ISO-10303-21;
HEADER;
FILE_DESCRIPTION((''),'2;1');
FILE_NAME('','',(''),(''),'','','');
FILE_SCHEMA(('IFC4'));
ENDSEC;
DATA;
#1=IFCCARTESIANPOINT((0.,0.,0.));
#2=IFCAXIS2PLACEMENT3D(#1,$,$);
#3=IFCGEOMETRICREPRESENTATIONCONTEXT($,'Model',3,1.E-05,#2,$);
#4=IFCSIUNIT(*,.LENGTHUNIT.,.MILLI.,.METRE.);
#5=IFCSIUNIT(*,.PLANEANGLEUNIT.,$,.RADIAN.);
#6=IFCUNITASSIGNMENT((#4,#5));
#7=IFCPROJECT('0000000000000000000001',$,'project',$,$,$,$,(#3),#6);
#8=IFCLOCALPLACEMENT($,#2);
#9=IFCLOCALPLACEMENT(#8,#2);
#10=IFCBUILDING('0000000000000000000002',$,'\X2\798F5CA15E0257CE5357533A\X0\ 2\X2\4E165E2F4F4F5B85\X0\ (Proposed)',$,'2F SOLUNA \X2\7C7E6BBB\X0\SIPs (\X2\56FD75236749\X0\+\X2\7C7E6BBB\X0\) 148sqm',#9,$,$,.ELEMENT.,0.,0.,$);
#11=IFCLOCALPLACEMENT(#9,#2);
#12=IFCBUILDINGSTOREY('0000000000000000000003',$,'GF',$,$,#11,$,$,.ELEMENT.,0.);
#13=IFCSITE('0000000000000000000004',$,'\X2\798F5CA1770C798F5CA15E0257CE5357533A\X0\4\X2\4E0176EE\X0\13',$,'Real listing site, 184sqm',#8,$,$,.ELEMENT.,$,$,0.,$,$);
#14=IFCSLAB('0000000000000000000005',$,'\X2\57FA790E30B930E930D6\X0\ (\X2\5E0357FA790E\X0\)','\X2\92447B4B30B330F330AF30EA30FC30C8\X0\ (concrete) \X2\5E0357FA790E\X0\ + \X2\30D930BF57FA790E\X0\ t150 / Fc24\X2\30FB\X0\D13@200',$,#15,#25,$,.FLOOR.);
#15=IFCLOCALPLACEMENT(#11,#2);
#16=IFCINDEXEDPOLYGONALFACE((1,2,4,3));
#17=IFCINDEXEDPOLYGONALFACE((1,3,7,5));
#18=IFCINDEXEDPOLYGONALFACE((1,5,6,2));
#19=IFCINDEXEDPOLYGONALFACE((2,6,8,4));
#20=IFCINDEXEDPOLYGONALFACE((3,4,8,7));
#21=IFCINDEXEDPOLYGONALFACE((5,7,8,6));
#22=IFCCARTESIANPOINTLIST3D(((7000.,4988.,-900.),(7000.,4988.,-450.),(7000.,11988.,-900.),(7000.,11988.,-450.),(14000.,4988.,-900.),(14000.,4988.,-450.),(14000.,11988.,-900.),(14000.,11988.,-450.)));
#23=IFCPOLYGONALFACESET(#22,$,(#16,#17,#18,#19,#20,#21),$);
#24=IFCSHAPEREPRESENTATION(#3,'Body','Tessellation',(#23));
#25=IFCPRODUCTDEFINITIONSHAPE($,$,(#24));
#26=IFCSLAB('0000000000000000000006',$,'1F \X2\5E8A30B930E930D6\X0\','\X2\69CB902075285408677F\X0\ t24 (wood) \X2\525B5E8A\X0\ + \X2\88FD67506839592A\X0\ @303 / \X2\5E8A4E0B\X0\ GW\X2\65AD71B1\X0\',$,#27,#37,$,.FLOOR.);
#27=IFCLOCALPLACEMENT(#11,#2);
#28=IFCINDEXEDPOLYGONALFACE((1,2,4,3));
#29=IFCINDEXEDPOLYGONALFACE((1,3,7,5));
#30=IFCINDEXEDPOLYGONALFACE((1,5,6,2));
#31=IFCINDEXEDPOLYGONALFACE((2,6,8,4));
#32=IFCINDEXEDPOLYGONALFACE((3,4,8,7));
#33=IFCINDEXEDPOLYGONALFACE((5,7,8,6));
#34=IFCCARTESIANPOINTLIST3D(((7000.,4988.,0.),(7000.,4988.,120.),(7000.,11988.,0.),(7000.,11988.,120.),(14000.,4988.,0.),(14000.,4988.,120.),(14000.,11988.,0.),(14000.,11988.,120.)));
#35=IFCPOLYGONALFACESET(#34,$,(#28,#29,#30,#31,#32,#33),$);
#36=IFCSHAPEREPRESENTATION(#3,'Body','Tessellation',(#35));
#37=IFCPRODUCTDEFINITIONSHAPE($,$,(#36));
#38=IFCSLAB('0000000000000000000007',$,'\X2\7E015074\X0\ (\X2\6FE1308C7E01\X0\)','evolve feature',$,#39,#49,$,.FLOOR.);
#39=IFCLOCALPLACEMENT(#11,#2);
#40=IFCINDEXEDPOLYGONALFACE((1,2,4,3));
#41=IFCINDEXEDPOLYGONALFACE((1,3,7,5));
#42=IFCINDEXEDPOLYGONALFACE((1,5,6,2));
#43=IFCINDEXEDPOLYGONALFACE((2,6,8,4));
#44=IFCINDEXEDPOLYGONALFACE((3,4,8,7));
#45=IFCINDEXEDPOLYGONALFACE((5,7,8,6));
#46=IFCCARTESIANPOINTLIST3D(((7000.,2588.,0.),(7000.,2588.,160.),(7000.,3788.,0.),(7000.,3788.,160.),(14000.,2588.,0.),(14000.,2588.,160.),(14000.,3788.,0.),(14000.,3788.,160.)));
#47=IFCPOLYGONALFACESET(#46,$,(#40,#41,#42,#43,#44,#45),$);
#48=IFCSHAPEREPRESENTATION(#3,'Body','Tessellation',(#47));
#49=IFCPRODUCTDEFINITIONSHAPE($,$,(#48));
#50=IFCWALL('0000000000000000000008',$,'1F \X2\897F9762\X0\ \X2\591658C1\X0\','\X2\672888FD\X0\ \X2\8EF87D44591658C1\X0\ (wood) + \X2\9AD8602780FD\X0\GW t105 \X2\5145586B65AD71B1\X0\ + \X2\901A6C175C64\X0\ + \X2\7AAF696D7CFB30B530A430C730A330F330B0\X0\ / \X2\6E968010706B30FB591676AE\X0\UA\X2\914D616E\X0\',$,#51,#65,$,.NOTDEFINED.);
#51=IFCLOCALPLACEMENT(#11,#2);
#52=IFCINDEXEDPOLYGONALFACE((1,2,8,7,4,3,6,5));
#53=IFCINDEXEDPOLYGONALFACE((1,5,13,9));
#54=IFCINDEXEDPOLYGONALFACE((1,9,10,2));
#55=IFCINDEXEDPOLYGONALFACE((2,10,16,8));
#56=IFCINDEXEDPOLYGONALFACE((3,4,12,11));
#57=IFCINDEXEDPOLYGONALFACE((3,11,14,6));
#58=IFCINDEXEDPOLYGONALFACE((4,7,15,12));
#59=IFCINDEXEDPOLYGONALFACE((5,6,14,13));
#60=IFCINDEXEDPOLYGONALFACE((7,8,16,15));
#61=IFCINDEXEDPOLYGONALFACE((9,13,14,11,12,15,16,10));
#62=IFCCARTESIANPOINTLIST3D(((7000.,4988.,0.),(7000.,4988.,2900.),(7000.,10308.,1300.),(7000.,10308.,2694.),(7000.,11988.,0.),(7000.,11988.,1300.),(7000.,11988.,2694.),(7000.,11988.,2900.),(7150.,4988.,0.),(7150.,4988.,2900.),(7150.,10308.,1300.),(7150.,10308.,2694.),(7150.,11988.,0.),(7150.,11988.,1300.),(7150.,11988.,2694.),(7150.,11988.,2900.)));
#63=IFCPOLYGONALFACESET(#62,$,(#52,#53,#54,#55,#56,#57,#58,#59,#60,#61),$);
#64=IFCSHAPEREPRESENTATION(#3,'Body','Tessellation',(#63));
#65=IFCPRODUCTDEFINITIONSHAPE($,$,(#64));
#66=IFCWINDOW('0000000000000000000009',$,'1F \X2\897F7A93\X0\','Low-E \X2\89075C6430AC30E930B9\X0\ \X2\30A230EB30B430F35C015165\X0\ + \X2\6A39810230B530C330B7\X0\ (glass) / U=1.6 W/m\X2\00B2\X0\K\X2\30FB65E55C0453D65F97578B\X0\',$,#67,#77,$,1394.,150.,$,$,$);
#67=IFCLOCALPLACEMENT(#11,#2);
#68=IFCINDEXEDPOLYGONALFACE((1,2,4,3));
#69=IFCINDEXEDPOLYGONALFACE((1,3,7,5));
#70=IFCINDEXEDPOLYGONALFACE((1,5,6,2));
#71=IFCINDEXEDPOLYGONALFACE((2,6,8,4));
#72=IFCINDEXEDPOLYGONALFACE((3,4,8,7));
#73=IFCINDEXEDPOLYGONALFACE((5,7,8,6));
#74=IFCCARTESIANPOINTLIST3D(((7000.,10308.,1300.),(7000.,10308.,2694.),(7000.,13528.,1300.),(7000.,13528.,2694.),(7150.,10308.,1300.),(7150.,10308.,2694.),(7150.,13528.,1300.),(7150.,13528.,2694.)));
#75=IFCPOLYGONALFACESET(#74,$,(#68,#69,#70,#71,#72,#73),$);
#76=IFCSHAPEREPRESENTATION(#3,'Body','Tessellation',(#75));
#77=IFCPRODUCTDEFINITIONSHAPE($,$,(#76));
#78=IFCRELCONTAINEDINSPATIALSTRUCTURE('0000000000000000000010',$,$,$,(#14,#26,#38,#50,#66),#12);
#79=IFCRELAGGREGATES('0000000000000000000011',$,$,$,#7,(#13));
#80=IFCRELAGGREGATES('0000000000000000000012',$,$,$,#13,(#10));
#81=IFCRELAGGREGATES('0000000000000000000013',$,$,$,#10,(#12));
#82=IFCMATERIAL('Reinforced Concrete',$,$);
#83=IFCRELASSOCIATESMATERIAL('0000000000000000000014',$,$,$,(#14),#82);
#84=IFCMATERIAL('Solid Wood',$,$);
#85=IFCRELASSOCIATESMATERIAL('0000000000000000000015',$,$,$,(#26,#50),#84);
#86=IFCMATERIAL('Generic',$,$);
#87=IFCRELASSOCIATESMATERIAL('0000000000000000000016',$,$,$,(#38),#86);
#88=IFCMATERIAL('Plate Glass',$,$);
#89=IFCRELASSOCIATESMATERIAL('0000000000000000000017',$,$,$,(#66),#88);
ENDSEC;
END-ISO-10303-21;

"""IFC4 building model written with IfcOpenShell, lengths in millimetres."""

from ifc_helpers import new_model, si_unit, frame, frame_2d, origin, place, context, project, spatial, rectangle, extrude, material, element, fill, save


model = new_model("IFC4")

# Units and contexts
model_context = context("Model", 3, precision=1e-05, world=origin())
ifc_project = project(units=[si_unit("LENGTHUNIT", "METRE", prefix="MILLI"), si_unit("PLANEANGLEUNIT", "RADIAN")], contexts=[model_context])

# Site, building, storey
site_placement = place(None, origin())
site = spatial("IfcSite", under=ifc_project, at=site_placement, Name="福岡県福岡市城南区4丁目13", ObjectType="Real listing site, 184sqm", CompositionType="ELEMENT", RefElevation=0.0)
building_placement = place(site_placement, origin())
building = spatial("IfcBuilding", under=site, at=building_placement, Name="福岡市城南区 2世帯住宅 (Proposed)", ObjectType="2F SOLUNA 籾殻SIPs (国産杉+籾殻) 148sqm", CompositionType="ELEMENT", ElevationOfRefHeight=0.0, ElevationOfTerrain=0.0)
storey_placement = place(building_placement, origin())
storey = spatial("IfcBuildingStorey", under=building, at=storey_placement, Name="GF", CompositionType="ELEMENT", Elevation=0.0)

# Slabs
ifc_material_1 = material(Name="Reinforced Concrete")
slab_1_placement = place(storey_placement, frame((3500.0, 2494.0, -450.0)))
element("IfcSlab", 1, at=slab_1_placement, inside=storey, material=ifc_material_1, Name="基礎スラブ (布基礎)", Description="鉄筋コンクリート (concrete) 布基礎 + ベタ基礎 t150 / Fc24・D13@200", PredefinedType="FLOOR", context=model_context, shape_type="SweptSolid", body=[
    extrude(rectangle(XDim=7000.0, YDim=7000.0, at=frame_2d((3500.0, 3500.0))), frame((3500.0, 2494.0, -450.0)), (0.0, 0.0, 1.0), 450.0),
])
ifc_material_2 = material(Name="Solid Wood")
slab_2_placement = place(storey_placement, frame((3500.0, 2494.0, 0.0)))
element("IfcSlab", 2, at=slab_2_placement, inside=storey, material=ifc_material_2, Name="1F 床スラブ", Description="構造用合板 t24 (wood) 剛床 + 製材根太 @303 / 床下 GW断熱", PredefinedType="FLOOR", context=model_context, shape_type="SweptSolid", body=[
    extrude(rectangle(XDim=7000.0, YDim=7000.0, at=frame_2d((3500.0, 3500.0))), frame((3500.0, 2494.0, 0.0)), (0.0, 0.0, 1.0), 120.0),
])
ifc_material_3 = material(Name="Generic")
slab_3_placement = place(storey_placement, frame((3500.0, 1294.0, 0.0)))
element("IfcSlab", 3, at=slab_3_placement, inside=storey, material=ifc_material_3, Name="縁側 (濡れ縁)", Description="evolve feature", PredefinedType="FLOOR", context=model_context, shape_type="SweptSolid", body=[
    extrude(rectangle(XDim=7000.0, YDim=1200.0, at=frame_2d((3500.0, 600.0))), frame((3500.0, 1294.0, 0.0)), (0.0, 0.0, 1.0), 160.0),
])

# Shared definitions
ifc_material_4 = material(Name="Plate Glass")

# Wall, opening, window
wall_1_placement = place(storey_placement, frame((3500.0, 2494.0, 0.0)))
wall_1 = element("IfcWall", 4, at=wall_1_placement, inside=storey, material=ifc_material_2, Name="1F 西面 外壁", Description="木製 軸組外壁 (wood) + 高性能GW t105 充填断熱 + 通気層 + 窯業系サイディング / 準耐火・外皮UA配慮", PredefinedType="NOTDEFINED", context=model_context, shape_type="SweptSolid", body=[
    extrude(rectangle(XDim=150.0, YDim=7000.0, at=frame_2d((75.0, 3500.0))), frame((3500.0, 2494.0, 0.0)), (0.0, 0.0, 1.0), 2900.0),
])
opening_1_placement = place(storey_placement, frame((3500.0, 5154.0, 650.0)))
opening_1 = element("IfcOpeningElement", 5, at=opening_1_placement, cuts=wall_1, PredefinedType="NOTDEFINED", context=model_context, shape_type="SweptSolid", body=[
    extrude(rectangle(XDim=150.0, YDim=3220.0, at=frame_2d((75.0, 1610.0))), frame((3500.0, 5154.0, 650.0)), (0.0, 0.0, 1.0), 1394.0),
])
window_1_placement = place(storey_placement, frame((3500.0, 5154.0, 650.0)))
window_1 = element("IfcWindow", 6, at=window_1_placement, inside=storey, material=ifc_material_4, Name="1F 西窓", Description="Low-E 複層ガラス アルゴン封入 + 樹脂サッシ (glass) / U=1.6 W/m²K・日射取得型", OverallHeight=1394.0, OverallWidth=150.0, context=model_context, shape_type="SweptSolid", body=[
    extrude(rectangle(XDim=150.0, YDim=3220.0, at=frame_2d((75.0, 1610.0))), frame((3500.0, 5154.0, 650.0)), (0.0, 0.0, 1.0), 1394.0),
])
fill(opening_1, window_1)

save(model, "model.ifc")
